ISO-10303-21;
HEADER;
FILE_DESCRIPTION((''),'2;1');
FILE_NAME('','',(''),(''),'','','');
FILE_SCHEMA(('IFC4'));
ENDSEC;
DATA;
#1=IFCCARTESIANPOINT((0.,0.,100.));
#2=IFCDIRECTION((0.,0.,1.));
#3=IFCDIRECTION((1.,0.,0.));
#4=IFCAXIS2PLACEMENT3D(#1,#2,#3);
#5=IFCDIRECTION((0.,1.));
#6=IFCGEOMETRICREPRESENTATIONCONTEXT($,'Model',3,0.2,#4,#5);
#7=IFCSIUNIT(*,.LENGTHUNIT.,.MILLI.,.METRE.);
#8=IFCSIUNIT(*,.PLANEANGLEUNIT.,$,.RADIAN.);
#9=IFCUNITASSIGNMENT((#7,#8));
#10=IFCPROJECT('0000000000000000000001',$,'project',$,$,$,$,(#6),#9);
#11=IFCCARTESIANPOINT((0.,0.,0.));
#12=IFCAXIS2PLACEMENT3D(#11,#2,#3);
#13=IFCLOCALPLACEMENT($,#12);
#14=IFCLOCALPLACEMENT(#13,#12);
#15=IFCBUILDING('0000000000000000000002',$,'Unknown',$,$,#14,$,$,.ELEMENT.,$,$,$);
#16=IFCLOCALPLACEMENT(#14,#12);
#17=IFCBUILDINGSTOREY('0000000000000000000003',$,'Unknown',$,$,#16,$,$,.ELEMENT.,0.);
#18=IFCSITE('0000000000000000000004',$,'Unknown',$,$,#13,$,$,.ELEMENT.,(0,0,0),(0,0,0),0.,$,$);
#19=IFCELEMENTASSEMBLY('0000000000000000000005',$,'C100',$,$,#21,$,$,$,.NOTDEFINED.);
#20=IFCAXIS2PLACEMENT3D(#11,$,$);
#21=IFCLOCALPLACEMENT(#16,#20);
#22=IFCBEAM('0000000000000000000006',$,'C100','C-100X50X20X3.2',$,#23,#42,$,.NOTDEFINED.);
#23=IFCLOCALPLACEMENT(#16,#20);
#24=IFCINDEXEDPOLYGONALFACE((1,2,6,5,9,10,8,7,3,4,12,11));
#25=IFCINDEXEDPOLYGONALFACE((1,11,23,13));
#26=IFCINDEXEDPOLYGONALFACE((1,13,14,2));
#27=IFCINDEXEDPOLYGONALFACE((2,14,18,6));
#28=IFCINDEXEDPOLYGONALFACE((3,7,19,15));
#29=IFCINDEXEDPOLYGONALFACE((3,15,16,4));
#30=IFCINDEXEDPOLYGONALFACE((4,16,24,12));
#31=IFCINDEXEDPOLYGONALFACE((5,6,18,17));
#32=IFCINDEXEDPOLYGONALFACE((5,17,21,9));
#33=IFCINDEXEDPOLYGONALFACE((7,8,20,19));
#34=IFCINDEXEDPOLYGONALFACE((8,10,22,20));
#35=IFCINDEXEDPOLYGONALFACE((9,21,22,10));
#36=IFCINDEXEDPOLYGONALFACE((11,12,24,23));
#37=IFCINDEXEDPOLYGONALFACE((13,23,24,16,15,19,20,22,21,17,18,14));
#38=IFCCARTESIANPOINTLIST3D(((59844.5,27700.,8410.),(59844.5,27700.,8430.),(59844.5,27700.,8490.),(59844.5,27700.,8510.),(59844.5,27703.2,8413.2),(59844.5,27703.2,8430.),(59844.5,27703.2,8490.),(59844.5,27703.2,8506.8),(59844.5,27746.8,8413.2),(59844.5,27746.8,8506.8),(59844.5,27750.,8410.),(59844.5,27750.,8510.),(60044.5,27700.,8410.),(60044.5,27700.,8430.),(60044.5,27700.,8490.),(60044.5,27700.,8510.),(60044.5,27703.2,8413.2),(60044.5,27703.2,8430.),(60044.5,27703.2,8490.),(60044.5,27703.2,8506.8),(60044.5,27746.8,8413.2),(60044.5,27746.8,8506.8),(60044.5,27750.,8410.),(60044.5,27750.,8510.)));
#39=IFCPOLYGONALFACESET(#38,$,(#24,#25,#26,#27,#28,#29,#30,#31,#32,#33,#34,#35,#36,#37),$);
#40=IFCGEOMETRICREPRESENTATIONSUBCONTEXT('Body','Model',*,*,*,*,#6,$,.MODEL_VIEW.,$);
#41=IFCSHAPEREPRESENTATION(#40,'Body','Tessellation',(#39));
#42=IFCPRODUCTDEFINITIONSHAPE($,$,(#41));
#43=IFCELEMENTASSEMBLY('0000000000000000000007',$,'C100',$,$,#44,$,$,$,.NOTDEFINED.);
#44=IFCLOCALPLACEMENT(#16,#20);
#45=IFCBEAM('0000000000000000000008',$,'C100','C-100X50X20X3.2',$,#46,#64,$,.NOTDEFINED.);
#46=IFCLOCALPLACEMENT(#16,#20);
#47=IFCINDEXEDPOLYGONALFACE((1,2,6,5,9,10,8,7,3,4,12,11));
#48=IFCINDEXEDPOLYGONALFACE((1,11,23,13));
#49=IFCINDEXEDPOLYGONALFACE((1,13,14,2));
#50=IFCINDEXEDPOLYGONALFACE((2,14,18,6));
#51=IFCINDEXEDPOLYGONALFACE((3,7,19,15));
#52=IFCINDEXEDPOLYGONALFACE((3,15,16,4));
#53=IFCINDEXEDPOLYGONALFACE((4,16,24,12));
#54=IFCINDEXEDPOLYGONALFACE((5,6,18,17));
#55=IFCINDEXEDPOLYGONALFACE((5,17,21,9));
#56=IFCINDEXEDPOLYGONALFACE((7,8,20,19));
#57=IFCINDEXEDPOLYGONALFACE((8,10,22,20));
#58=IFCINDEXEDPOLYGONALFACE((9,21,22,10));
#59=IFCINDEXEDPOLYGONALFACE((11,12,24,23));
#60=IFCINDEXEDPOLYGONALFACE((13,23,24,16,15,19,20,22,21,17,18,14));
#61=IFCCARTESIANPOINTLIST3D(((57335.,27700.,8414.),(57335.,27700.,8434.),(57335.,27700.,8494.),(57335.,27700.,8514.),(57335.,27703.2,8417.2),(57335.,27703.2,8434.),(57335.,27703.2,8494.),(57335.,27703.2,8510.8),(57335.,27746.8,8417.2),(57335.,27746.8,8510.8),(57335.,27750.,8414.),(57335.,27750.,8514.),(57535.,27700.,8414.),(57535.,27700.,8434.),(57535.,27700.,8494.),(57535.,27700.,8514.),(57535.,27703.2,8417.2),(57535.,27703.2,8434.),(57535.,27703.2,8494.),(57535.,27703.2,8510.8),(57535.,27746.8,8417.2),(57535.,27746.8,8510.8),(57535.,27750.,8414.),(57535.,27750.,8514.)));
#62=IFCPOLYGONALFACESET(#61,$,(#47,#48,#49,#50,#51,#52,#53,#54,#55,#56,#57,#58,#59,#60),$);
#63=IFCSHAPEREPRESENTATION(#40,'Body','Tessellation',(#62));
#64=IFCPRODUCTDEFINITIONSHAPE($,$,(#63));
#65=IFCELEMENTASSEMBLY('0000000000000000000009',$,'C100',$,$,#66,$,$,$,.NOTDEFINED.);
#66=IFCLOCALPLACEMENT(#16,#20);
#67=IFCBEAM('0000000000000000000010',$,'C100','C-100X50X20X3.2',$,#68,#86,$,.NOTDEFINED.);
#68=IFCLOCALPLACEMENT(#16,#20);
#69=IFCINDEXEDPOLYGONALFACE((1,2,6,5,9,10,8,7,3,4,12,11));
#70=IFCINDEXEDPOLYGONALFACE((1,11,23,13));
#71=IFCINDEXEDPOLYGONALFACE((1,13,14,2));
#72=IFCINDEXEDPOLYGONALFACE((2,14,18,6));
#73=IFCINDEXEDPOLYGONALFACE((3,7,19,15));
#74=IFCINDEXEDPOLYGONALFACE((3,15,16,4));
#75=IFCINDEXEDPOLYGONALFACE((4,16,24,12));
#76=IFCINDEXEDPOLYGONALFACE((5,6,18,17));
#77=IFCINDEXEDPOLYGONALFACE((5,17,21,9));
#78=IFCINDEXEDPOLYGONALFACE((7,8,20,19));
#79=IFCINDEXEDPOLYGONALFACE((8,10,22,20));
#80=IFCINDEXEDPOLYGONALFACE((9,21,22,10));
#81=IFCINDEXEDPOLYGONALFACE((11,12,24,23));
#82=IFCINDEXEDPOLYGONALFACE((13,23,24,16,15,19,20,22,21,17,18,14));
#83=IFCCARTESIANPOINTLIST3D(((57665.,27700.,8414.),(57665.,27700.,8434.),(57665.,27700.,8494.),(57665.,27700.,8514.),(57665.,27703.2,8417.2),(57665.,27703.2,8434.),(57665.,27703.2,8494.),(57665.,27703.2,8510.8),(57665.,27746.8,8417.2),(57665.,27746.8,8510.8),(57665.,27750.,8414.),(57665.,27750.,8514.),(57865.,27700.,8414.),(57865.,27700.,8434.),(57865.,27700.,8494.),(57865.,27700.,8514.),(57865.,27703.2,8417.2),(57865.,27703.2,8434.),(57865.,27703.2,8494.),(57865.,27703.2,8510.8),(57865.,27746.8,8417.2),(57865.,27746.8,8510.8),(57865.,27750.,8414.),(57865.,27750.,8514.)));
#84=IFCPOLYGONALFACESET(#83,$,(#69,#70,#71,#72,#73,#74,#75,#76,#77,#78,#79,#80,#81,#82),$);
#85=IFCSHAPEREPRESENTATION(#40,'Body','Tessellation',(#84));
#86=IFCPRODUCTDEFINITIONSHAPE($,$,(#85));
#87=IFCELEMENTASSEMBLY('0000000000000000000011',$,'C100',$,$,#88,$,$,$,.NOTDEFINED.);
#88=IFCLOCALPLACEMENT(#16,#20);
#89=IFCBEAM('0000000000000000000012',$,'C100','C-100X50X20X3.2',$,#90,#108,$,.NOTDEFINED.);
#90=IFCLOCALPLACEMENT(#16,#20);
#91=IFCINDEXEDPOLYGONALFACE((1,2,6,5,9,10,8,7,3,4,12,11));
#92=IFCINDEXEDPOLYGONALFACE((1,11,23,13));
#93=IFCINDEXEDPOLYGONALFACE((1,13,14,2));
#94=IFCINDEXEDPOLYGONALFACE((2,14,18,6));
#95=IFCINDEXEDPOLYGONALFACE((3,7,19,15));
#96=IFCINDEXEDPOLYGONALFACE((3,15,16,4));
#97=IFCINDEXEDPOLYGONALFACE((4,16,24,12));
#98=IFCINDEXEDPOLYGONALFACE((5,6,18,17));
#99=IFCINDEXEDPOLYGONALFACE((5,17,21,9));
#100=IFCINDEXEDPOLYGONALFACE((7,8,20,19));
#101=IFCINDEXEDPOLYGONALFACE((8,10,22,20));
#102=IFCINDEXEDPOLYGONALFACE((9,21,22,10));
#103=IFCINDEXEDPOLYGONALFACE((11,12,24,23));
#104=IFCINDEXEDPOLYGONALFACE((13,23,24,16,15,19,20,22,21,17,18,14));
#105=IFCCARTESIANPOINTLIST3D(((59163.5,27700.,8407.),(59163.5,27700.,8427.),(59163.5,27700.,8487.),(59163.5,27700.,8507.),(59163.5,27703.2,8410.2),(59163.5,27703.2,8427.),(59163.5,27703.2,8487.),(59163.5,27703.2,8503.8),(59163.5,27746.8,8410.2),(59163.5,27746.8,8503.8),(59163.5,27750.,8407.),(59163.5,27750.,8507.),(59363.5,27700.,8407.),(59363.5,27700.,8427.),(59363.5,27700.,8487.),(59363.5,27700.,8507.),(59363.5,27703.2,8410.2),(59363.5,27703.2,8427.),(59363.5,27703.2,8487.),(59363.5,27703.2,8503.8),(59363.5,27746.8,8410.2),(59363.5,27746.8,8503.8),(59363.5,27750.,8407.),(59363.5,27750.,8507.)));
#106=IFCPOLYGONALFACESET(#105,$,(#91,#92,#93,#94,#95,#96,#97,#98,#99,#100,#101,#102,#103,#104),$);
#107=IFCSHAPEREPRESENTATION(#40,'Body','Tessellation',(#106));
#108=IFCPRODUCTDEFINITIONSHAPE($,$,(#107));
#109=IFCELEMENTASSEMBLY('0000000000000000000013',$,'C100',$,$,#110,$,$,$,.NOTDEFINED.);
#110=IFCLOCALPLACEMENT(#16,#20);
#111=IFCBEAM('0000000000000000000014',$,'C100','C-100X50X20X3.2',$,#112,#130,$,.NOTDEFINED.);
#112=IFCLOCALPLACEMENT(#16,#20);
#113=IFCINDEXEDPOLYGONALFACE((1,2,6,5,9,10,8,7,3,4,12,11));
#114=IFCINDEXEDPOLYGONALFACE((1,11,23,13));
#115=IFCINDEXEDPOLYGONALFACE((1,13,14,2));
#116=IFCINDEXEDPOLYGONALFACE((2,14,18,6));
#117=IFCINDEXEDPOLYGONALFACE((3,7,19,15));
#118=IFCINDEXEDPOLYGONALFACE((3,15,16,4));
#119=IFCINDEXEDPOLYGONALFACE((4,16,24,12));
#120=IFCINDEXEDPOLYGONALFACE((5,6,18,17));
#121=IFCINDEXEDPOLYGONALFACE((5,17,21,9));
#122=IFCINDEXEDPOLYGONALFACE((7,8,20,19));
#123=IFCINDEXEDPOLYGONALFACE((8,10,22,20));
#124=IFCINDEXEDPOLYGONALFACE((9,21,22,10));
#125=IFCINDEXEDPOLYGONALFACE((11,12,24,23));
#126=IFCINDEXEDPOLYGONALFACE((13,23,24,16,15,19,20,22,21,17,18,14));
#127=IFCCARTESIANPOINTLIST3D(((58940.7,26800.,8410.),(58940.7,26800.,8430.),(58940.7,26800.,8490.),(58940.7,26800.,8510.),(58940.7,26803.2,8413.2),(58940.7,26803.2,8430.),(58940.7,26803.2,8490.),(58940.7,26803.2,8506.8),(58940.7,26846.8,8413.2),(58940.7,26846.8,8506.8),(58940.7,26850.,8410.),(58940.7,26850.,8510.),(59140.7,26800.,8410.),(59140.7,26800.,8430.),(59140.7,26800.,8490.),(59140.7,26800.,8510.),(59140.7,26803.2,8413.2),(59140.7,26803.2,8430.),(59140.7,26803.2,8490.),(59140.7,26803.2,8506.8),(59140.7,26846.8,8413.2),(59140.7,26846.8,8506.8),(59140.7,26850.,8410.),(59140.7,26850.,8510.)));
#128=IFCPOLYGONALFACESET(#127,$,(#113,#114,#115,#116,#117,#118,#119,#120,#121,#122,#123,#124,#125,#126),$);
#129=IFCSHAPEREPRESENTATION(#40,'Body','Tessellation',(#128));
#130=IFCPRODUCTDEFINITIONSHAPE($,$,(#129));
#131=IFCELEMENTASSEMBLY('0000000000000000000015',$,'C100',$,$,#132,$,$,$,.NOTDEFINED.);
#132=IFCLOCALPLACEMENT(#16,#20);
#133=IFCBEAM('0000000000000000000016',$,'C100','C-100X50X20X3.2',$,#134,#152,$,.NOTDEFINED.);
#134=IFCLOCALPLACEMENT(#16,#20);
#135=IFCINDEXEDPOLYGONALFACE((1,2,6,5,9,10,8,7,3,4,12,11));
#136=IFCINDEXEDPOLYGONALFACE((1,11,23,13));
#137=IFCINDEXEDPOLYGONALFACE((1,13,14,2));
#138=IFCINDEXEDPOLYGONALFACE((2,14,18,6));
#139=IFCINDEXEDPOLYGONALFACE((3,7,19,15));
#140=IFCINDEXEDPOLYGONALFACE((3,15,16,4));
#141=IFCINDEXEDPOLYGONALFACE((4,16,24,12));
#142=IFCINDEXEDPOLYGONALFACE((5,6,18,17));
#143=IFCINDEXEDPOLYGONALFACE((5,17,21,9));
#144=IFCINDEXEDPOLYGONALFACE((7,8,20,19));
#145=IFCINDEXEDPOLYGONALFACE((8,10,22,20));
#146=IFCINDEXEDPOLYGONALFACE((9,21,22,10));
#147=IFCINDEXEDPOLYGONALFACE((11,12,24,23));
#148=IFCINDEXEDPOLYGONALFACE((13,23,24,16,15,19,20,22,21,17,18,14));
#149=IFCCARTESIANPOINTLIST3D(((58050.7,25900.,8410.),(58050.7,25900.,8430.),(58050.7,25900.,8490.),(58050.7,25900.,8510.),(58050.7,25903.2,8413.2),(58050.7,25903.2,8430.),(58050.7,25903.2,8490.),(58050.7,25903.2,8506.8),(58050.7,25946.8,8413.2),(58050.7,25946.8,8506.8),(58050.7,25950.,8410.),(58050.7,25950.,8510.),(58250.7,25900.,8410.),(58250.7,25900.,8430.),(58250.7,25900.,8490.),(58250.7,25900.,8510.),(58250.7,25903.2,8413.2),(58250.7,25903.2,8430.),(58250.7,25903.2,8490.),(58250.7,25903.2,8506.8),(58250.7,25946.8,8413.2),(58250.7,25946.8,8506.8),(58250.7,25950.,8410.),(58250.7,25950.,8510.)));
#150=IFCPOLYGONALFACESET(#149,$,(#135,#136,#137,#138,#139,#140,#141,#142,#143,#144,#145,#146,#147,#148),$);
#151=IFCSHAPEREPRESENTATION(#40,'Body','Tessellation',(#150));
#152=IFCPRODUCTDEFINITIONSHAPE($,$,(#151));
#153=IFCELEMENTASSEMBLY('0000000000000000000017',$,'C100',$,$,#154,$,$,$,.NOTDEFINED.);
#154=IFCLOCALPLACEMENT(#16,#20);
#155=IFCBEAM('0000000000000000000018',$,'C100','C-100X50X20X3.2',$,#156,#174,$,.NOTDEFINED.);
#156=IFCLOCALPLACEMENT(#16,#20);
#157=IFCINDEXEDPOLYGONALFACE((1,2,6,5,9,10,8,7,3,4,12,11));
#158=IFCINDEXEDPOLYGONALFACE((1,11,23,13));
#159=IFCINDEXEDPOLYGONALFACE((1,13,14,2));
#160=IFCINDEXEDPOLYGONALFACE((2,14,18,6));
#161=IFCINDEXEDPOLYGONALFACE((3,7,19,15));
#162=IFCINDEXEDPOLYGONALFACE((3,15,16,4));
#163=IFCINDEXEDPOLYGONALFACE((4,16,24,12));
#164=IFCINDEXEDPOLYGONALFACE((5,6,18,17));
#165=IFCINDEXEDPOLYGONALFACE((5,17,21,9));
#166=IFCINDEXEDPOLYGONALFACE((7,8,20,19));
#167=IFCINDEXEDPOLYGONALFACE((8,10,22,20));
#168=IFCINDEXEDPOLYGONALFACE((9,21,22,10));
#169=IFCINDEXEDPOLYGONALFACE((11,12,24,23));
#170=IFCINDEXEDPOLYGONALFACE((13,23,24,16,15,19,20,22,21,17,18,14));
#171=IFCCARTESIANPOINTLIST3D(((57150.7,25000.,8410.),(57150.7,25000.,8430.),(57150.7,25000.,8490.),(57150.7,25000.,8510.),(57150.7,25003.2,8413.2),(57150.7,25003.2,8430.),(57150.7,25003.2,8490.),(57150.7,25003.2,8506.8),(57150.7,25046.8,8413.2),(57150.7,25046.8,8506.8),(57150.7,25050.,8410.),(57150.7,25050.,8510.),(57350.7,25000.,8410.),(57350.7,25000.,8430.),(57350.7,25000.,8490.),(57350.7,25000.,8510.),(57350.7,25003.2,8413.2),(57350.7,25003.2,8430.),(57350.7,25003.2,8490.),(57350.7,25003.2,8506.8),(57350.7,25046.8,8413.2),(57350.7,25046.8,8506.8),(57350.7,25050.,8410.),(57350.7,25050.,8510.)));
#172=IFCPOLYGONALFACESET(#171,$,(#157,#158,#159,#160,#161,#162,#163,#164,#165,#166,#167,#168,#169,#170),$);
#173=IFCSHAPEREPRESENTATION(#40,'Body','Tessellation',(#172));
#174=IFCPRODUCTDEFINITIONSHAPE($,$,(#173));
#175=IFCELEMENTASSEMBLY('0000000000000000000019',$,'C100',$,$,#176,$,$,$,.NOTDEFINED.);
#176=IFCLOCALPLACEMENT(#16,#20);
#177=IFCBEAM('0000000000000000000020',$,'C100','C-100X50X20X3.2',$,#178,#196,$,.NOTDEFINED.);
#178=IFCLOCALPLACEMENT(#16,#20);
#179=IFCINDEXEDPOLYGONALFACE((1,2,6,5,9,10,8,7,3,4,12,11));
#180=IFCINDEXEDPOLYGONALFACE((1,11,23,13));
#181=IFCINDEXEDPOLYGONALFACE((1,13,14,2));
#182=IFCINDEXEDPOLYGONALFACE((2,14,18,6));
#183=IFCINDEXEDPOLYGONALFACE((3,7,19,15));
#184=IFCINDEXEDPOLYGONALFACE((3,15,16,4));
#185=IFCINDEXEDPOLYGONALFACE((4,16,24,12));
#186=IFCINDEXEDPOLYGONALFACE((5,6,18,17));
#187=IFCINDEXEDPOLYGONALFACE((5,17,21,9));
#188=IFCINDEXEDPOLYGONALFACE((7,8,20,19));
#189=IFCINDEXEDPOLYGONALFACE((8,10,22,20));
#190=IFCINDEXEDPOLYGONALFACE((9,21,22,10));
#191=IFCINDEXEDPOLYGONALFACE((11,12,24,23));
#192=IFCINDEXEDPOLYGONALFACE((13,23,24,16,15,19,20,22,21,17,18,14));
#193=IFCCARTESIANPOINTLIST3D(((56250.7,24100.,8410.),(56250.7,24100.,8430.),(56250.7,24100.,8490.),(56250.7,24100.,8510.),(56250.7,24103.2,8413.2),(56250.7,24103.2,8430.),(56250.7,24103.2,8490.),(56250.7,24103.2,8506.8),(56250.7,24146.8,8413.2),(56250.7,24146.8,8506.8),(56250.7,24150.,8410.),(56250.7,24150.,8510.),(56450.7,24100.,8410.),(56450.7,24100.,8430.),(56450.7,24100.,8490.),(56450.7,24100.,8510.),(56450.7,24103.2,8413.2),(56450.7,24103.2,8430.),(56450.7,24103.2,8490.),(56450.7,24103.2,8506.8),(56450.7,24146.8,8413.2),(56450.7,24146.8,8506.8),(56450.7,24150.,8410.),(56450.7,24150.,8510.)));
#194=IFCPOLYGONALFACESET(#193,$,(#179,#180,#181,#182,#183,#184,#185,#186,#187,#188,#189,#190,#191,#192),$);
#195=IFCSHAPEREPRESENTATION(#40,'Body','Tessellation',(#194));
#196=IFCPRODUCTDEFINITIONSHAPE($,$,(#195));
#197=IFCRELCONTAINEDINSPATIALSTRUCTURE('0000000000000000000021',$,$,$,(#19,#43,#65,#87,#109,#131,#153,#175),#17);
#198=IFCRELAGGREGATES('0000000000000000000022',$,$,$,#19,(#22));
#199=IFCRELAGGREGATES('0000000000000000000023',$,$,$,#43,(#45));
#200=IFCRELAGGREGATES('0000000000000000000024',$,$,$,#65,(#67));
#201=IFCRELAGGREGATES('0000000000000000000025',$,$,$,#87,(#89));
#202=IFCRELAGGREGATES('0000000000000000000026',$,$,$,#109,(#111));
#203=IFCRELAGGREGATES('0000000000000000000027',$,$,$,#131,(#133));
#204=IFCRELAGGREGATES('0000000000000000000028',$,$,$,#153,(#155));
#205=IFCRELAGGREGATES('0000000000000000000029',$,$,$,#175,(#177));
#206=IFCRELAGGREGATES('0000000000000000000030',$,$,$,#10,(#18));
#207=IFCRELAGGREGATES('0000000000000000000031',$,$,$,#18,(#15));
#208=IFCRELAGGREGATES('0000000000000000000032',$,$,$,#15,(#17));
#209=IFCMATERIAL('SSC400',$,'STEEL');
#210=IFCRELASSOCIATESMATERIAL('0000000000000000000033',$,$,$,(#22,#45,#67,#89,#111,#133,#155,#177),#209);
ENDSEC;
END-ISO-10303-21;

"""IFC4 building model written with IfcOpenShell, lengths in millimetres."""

from ifc_helpers import new_model, si_unit, direction, frame, origin_with_axes, place, context, subcontext, project, spatial, line, indexed_curve, outline, extrude, material, element, aggregate, save


model = new_model("IFC4")

# Units and contexts
model_context = context("Model", 3, precision=0.2, world=frame((0.0, 0.0, 100.0), z_axis=(0.0, 0.0, 1.0), x_axis=(1.0, 0.0, 0.0)), true_north=direction((0.0, 1.0)))
body_context = subcontext(model_context, "Body", "Model", "MODEL_VIEW")
ifc_project = project(units=[si_unit("LENGTHUNIT", "METRE", prefix="MILLI"), si_unit("PLANEANGLEUNIT", "RADIAN")], contexts=[model_context])

# Site, building, storey
site_placement = place(None, origin_with_axes())
site = spatial("IfcSite", under=ifc_project, at=site_placement, Name="Unknown", CompositionType="ELEMENT", RefLatitude=(0, 0, 0), RefLongitude=(0, 0, 0), RefElevation=0.0)
building_placement = place(site_placement, origin_with_axes())
building = spatial("IfcBuilding", under=site, at=building_placement, Name="Unknown", CompositionType="ELEMENT")
storey_placement = place(building_placement, origin_with_axes())
storey = spatial("IfcBuildingStorey", under=building, at=storey_placement, Name="Unknown", CompositionType="ELEMENT", Elevation=0.0)

# Element assemblies, beams
assembly_1_placement = place(storey_placement, frame((59844.5, 27725.0, 8460.0), z_axis=(0.0, -1.0, 0.0), x_axis=(1.0, 0.0, 0.0)))
assembly_1 = element("IfcElementAssembly", 1, at=assembly_1_placement, inside=storey, Name="C100", PredefinedType="NOTDEFINED")
ifc_material_1 = material(Name="SSC400", Category="STEEL")
beam_1_placement = place(assembly_1_placement, origin_with_axes())
beam_1 = element("IfcBeam", 2, at=beam_1_placement, material=ifc_material_1, Name="C100", Description="C-100X50X20X3.2", PredefinedType="NOTDEFINED", context=body_context, shape_type="SolidModel", body=[
    extrude(outline(indexed_curve([(25.0, -50.0), (25.0, -30.0), (21.8, -30.0), (21.8, -46.8), (-21.8, -46.8), (-21.8, 46.8), (21.8, 46.8), (21.8, 30.0), (25.0, 30.0), (25.0, 50.0), (-25.0, 50.0), (-25.0, -50.0)], segments=[line(1, 2, 3, 4, 5, 6, 7, 8, 9, 10, 11, 12, 1)])), frame((0.0, 0.0, 0.0), z_axis=(-1.0, 0.0, 0.0), x_axis=(0.0, 0.0, 1.0)), (0.0, 0.0, -1.0), 200.0),
])
aggregate(assembly_1, [beam_1])
assembly_2_placement = place(storey_placement, frame((57335.0, 27725.0, 8464.0), z_axis=(0.0, -1.0, 0.0), x_axis=(1.0, 0.0, 0.0)))
assembly_2 = element("IfcElementAssembly", 3, at=assembly_2_placement, inside=storey, Name="C100", PredefinedType="NOTDEFINED")
beam_2_placement = place(assembly_2_placement, origin_with_axes())
beam_2 = element("IfcBeam", 4, at=beam_2_placement, material=ifc_material_1, Name="C100", Description="C-100X50X20X3.2", PredefinedType="NOTDEFINED", context=body_context, shape_type="SolidModel", body=[
    extrude(outline(indexed_curve([(25.0, -50.0), (25.0, -30.0), (21.8, -30.0), (21.8, -46.8), (-21.8, -46.8), (-21.8, 46.8), (21.8, 46.8), (21.8, 30.0), (25.0, 30.0), (25.0, 50.0), (-25.0, 50.0), (-25.0, -50.0)], segments=[line(1, 2, 3, 4, 5, 6, 7, 8, 9, 10, 11, 12, 1)])), frame((0.0, 0.0, 0.0), z_axis=(-1.0, 0.0, 0.0), x_axis=(0.0, 0.0, 1.0)), (0.0, 0.0, -1.0), 200.0),
])
aggregate(assembly_2, [beam_2])
assembly_3_placement = place(storey_placement, frame((57665.0, 27725.0, 8464.0), z_axis=(0.0, -1.0, 0.0), x_axis=(1.0, 0.0, 0.0)))
assembly_3 = element("IfcElementAssembly", 5, at=assembly_3_placement, inside=storey, Name="C100", PredefinedType="NOTDEFINED")
beam_3_placement = place(assembly_3_placement, origin_with_axes())
beam_3 = element("IfcBeam", 6, at=beam_3_placement, material=ifc_material_1, Name="C100", Description="C-100X50X20X3.2", PredefinedType="NOTDEFINED", context=body_context, shape_type="SolidModel", body=[
    extrude(outline(indexed_curve([(25.0, -50.0), (25.0, -30.0), (21.8, -30.0), (21.8, -46.8), (-21.8, -46.8), (-21.8, 46.8), (21.8, 46.8), (21.8, 30.0), (25.0, 30.0), (25.0, 50.0), (-25.0, 50.0), (-25.0, -50.0)], segments=[line(1, 2, 3, 4, 5, 6, 7, 8, 9, 10, 11, 12, 1)])), frame((0.0, 0.0, 0.0), z_axis=(-1.0, 0.0, 0.0), x_axis=(0.0, 0.0, 1.0)), (0.0, 0.0, -1.0), 200.0),
])
aggregate(assembly_3, [beam_3])
assembly_4_placement = place(storey_placement, frame((59163.5, 27725.0, 8457.0), z_axis=(0.0, -1.0, 0.0), x_axis=(1.0, 0.0, 0.0)))
assembly_4 = element("IfcElementAssembly", 7, at=assembly_4_placement, inside=storey, Name="C100", PredefinedType="NOTDEFINED")
beam_4_placement = place(assembly_4_placement, origin_with_axes())
beam_4 = element("IfcBeam", 8, at=beam_4_placement, material=ifc_material_1, Name="C100", Description="C-100X50X20X3.2", PredefinedType="NOTDEFINED", context=body_context, shape_type="SolidModel", body=[
    extrude(outline(indexed_curve([(25.0, -50.0), (25.0, -30.0), (21.8, -30.0), (21.8, -46.8), (-21.8, -46.8), (-21.8, 46.8), (21.8, 46.8), (21.8, 30.0), (25.0, 30.0), (25.0, 50.0), (-25.0, 50.0), (-25.0, -50.0)], segments=[line(1, 2, 3, 4, 5, 6, 7, 8, 9, 10, 11, 12, 1)])), frame((0.0, 0.0, 0.0), z_axis=(-1.0, 0.0, 0.0), x_axis=(0.0, 0.0, 1.0)), (0.0, 0.0, -1.0), 200.0),
])
aggregate(assembly_4, [beam_4])
assembly_5_placement = place(storey_placement, frame((58940.7, 26825.0, 8460.0), z_axis=(0.0, -1.0, 0.0), x_axis=(1.0, 0.0, 0.0)))
assembly_5 = element("IfcElementAssembly", 9, at=assembly_5_placement, inside=storey, Name="C100", PredefinedType="NOTDEFINED")
beam_5_placement = place(assembly_5_placement, origin_with_axes())
beam_5 = element("IfcBeam", 10, at=beam_5_placement, material=ifc_material_1, Name="C100", Description="C-100X50X20X3.2", PredefinedType="NOTDEFINED", context=body_context, shape_type="SolidModel", body=[
    extrude(outline(indexed_curve([(25.0, -50.0), (25.0, -30.0), (21.8, -30.0), (21.8, -46.8), (-21.8, -46.8), (-21.8, 46.8), (21.8, 46.8), (21.8, 30.0), (25.0, 30.0), (25.0, 50.0), (-25.0, 50.0), (-25.0, -50.0)], segments=[line(1, 2, 3, 4, 5, 6, 7, 8, 9, 10, 11, 12, 1)])), frame((0.0, 0.0, 0.0), z_axis=(-1.0, 0.0, 0.0), x_axis=(0.0, 0.0, 1.0)), (0.0, 0.0, -1.0), 200.0),
])
aggregate(assembly_5, [beam_5])
assembly_6_placement = place(storey_placement, frame((58050.7, 25925.0, 8460.0), z_axis=(0.0, -1.0, 0.0), x_axis=(1.0, 0.0, 0.0)))
assembly_6 = element("IfcElementAssembly", 11, at=assembly_6_placement, inside=storey, Name="C100", PredefinedType="NOTDEFINED")
beam_6_placement = place(assembly_6_placement, origin_with_axes())
beam_6 = element("IfcBeam", 12, at=beam_6_placement, material=ifc_material_1, Name="C100", Description="C-100X50X20X3.2", PredefinedType="NOTDEFINED", context=body_context, shape_type="SolidModel", body=[
    extrude(outline(indexed_curve([(25.0, -50.0), (25.0, -30.0), (21.8, -30.0), (21.8, -46.8), (-21.8, -46.8), (-21.8, 46.8), (21.8, 46.8), (21.8, 30.0), (25.0, 30.0), (25.0, 50.0), (-25.0, 50.0), (-25.0, -50.0)], segments=[line(1, 2, 3, 4, 5, 6, 7, 8, 9, 10, 11, 12, 1)])), frame((0.0, 0.0, 0.0), z_axis=(-1.0, 0.0, 0.0), x_axis=(0.0, 0.0, 1.0)), (0.0, 0.0, -1.0), 200.0),
])
aggregate(assembly_6, [beam_6])
assembly_7_placement = place(storey_placement, frame((57150.7, 25025.0, 8460.0), z_axis=(0.0, -1.0, 0.0), x_axis=(1.0, 0.0, 0.0)))
assembly_7 = element("IfcElementAssembly", 13, at=assembly_7_placement, inside=storey, Name="C100", PredefinedType="NOTDEFINED")
beam_7_placement = place(assembly_7_placement, origin_with_axes())
beam_7 = element("IfcBeam", 14, at=beam_7_placement, material=ifc_material_1, Name="C100", Description="C-100X50X20X3.2", PredefinedType="NOTDEFINED", context=body_context, shape_type="SolidModel", body=[
    extrude(outline(indexed_curve([(25.0, -50.0), (25.0, -30.0), (21.8, -30.0), (21.8, -46.8), (-21.8, -46.8), (-21.8, 46.8), (21.8, 46.8), (21.8, 30.0), (25.0, 30.0), (25.0, 50.0), (-25.0, 50.0), (-25.0, -50.0)], segments=[line(1, 2, 3, 4, 5, 6, 7, 8, 9, 10, 11, 12, 1)])), frame((0.0, 0.0, 0.0), z_axis=(-1.0, 0.0, 0.0), x_axis=(0.0, 0.0, 1.0)), (0.0, 0.0, -1.0), 200.0),
])
aggregate(assembly_7, [beam_7])
assembly_8_placement = place(storey_placement, frame((56250.7, 24125.0, 8460.0), z_axis=(0.0, -1.0, 0.0), x_axis=(1.0, 0.0, 0.0)))
assembly_8 = element("IfcElementAssembly", 15, at=assembly_8_placement, inside=storey, Name="C100", PredefinedType="NOTDEFINED")
beam_8_placement = place(assembly_8_placement, origin_with_axes())
beam_8 = element("IfcBeam", 16, at=beam_8_placement, material=ifc_material_1, Name="C100", Description="C-100X50X20X3.2", PredefinedType="NOTDEFINED", context=body_context, shape_type="SolidModel", body=[
    extrude(outline(indexed_curve([(25.0, -50.0), (25.0, -30.0), (21.8, -30.0), (21.8, -46.8), (-21.8, -46.8), (-21.8, 46.8), (21.8, 46.8), (21.8, 30.0), (25.0, 30.0), (25.0, 50.0), (-25.0, 50.0), (-25.0, -50.0)], segments=[line(1, 2, 3, 4, 5, 6, 7, 8, 9, 10, 11, 12, 1)])), frame((0.0, 0.0, 0.0), z_axis=(-1.0, 0.0, 0.0), x_axis=(0.0, 0.0, 1.0)), (0.0, 0.0, -1.0), 200.0),
])
aggregate(assembly_8, [beam_8])

save(model, "model.ifc")
